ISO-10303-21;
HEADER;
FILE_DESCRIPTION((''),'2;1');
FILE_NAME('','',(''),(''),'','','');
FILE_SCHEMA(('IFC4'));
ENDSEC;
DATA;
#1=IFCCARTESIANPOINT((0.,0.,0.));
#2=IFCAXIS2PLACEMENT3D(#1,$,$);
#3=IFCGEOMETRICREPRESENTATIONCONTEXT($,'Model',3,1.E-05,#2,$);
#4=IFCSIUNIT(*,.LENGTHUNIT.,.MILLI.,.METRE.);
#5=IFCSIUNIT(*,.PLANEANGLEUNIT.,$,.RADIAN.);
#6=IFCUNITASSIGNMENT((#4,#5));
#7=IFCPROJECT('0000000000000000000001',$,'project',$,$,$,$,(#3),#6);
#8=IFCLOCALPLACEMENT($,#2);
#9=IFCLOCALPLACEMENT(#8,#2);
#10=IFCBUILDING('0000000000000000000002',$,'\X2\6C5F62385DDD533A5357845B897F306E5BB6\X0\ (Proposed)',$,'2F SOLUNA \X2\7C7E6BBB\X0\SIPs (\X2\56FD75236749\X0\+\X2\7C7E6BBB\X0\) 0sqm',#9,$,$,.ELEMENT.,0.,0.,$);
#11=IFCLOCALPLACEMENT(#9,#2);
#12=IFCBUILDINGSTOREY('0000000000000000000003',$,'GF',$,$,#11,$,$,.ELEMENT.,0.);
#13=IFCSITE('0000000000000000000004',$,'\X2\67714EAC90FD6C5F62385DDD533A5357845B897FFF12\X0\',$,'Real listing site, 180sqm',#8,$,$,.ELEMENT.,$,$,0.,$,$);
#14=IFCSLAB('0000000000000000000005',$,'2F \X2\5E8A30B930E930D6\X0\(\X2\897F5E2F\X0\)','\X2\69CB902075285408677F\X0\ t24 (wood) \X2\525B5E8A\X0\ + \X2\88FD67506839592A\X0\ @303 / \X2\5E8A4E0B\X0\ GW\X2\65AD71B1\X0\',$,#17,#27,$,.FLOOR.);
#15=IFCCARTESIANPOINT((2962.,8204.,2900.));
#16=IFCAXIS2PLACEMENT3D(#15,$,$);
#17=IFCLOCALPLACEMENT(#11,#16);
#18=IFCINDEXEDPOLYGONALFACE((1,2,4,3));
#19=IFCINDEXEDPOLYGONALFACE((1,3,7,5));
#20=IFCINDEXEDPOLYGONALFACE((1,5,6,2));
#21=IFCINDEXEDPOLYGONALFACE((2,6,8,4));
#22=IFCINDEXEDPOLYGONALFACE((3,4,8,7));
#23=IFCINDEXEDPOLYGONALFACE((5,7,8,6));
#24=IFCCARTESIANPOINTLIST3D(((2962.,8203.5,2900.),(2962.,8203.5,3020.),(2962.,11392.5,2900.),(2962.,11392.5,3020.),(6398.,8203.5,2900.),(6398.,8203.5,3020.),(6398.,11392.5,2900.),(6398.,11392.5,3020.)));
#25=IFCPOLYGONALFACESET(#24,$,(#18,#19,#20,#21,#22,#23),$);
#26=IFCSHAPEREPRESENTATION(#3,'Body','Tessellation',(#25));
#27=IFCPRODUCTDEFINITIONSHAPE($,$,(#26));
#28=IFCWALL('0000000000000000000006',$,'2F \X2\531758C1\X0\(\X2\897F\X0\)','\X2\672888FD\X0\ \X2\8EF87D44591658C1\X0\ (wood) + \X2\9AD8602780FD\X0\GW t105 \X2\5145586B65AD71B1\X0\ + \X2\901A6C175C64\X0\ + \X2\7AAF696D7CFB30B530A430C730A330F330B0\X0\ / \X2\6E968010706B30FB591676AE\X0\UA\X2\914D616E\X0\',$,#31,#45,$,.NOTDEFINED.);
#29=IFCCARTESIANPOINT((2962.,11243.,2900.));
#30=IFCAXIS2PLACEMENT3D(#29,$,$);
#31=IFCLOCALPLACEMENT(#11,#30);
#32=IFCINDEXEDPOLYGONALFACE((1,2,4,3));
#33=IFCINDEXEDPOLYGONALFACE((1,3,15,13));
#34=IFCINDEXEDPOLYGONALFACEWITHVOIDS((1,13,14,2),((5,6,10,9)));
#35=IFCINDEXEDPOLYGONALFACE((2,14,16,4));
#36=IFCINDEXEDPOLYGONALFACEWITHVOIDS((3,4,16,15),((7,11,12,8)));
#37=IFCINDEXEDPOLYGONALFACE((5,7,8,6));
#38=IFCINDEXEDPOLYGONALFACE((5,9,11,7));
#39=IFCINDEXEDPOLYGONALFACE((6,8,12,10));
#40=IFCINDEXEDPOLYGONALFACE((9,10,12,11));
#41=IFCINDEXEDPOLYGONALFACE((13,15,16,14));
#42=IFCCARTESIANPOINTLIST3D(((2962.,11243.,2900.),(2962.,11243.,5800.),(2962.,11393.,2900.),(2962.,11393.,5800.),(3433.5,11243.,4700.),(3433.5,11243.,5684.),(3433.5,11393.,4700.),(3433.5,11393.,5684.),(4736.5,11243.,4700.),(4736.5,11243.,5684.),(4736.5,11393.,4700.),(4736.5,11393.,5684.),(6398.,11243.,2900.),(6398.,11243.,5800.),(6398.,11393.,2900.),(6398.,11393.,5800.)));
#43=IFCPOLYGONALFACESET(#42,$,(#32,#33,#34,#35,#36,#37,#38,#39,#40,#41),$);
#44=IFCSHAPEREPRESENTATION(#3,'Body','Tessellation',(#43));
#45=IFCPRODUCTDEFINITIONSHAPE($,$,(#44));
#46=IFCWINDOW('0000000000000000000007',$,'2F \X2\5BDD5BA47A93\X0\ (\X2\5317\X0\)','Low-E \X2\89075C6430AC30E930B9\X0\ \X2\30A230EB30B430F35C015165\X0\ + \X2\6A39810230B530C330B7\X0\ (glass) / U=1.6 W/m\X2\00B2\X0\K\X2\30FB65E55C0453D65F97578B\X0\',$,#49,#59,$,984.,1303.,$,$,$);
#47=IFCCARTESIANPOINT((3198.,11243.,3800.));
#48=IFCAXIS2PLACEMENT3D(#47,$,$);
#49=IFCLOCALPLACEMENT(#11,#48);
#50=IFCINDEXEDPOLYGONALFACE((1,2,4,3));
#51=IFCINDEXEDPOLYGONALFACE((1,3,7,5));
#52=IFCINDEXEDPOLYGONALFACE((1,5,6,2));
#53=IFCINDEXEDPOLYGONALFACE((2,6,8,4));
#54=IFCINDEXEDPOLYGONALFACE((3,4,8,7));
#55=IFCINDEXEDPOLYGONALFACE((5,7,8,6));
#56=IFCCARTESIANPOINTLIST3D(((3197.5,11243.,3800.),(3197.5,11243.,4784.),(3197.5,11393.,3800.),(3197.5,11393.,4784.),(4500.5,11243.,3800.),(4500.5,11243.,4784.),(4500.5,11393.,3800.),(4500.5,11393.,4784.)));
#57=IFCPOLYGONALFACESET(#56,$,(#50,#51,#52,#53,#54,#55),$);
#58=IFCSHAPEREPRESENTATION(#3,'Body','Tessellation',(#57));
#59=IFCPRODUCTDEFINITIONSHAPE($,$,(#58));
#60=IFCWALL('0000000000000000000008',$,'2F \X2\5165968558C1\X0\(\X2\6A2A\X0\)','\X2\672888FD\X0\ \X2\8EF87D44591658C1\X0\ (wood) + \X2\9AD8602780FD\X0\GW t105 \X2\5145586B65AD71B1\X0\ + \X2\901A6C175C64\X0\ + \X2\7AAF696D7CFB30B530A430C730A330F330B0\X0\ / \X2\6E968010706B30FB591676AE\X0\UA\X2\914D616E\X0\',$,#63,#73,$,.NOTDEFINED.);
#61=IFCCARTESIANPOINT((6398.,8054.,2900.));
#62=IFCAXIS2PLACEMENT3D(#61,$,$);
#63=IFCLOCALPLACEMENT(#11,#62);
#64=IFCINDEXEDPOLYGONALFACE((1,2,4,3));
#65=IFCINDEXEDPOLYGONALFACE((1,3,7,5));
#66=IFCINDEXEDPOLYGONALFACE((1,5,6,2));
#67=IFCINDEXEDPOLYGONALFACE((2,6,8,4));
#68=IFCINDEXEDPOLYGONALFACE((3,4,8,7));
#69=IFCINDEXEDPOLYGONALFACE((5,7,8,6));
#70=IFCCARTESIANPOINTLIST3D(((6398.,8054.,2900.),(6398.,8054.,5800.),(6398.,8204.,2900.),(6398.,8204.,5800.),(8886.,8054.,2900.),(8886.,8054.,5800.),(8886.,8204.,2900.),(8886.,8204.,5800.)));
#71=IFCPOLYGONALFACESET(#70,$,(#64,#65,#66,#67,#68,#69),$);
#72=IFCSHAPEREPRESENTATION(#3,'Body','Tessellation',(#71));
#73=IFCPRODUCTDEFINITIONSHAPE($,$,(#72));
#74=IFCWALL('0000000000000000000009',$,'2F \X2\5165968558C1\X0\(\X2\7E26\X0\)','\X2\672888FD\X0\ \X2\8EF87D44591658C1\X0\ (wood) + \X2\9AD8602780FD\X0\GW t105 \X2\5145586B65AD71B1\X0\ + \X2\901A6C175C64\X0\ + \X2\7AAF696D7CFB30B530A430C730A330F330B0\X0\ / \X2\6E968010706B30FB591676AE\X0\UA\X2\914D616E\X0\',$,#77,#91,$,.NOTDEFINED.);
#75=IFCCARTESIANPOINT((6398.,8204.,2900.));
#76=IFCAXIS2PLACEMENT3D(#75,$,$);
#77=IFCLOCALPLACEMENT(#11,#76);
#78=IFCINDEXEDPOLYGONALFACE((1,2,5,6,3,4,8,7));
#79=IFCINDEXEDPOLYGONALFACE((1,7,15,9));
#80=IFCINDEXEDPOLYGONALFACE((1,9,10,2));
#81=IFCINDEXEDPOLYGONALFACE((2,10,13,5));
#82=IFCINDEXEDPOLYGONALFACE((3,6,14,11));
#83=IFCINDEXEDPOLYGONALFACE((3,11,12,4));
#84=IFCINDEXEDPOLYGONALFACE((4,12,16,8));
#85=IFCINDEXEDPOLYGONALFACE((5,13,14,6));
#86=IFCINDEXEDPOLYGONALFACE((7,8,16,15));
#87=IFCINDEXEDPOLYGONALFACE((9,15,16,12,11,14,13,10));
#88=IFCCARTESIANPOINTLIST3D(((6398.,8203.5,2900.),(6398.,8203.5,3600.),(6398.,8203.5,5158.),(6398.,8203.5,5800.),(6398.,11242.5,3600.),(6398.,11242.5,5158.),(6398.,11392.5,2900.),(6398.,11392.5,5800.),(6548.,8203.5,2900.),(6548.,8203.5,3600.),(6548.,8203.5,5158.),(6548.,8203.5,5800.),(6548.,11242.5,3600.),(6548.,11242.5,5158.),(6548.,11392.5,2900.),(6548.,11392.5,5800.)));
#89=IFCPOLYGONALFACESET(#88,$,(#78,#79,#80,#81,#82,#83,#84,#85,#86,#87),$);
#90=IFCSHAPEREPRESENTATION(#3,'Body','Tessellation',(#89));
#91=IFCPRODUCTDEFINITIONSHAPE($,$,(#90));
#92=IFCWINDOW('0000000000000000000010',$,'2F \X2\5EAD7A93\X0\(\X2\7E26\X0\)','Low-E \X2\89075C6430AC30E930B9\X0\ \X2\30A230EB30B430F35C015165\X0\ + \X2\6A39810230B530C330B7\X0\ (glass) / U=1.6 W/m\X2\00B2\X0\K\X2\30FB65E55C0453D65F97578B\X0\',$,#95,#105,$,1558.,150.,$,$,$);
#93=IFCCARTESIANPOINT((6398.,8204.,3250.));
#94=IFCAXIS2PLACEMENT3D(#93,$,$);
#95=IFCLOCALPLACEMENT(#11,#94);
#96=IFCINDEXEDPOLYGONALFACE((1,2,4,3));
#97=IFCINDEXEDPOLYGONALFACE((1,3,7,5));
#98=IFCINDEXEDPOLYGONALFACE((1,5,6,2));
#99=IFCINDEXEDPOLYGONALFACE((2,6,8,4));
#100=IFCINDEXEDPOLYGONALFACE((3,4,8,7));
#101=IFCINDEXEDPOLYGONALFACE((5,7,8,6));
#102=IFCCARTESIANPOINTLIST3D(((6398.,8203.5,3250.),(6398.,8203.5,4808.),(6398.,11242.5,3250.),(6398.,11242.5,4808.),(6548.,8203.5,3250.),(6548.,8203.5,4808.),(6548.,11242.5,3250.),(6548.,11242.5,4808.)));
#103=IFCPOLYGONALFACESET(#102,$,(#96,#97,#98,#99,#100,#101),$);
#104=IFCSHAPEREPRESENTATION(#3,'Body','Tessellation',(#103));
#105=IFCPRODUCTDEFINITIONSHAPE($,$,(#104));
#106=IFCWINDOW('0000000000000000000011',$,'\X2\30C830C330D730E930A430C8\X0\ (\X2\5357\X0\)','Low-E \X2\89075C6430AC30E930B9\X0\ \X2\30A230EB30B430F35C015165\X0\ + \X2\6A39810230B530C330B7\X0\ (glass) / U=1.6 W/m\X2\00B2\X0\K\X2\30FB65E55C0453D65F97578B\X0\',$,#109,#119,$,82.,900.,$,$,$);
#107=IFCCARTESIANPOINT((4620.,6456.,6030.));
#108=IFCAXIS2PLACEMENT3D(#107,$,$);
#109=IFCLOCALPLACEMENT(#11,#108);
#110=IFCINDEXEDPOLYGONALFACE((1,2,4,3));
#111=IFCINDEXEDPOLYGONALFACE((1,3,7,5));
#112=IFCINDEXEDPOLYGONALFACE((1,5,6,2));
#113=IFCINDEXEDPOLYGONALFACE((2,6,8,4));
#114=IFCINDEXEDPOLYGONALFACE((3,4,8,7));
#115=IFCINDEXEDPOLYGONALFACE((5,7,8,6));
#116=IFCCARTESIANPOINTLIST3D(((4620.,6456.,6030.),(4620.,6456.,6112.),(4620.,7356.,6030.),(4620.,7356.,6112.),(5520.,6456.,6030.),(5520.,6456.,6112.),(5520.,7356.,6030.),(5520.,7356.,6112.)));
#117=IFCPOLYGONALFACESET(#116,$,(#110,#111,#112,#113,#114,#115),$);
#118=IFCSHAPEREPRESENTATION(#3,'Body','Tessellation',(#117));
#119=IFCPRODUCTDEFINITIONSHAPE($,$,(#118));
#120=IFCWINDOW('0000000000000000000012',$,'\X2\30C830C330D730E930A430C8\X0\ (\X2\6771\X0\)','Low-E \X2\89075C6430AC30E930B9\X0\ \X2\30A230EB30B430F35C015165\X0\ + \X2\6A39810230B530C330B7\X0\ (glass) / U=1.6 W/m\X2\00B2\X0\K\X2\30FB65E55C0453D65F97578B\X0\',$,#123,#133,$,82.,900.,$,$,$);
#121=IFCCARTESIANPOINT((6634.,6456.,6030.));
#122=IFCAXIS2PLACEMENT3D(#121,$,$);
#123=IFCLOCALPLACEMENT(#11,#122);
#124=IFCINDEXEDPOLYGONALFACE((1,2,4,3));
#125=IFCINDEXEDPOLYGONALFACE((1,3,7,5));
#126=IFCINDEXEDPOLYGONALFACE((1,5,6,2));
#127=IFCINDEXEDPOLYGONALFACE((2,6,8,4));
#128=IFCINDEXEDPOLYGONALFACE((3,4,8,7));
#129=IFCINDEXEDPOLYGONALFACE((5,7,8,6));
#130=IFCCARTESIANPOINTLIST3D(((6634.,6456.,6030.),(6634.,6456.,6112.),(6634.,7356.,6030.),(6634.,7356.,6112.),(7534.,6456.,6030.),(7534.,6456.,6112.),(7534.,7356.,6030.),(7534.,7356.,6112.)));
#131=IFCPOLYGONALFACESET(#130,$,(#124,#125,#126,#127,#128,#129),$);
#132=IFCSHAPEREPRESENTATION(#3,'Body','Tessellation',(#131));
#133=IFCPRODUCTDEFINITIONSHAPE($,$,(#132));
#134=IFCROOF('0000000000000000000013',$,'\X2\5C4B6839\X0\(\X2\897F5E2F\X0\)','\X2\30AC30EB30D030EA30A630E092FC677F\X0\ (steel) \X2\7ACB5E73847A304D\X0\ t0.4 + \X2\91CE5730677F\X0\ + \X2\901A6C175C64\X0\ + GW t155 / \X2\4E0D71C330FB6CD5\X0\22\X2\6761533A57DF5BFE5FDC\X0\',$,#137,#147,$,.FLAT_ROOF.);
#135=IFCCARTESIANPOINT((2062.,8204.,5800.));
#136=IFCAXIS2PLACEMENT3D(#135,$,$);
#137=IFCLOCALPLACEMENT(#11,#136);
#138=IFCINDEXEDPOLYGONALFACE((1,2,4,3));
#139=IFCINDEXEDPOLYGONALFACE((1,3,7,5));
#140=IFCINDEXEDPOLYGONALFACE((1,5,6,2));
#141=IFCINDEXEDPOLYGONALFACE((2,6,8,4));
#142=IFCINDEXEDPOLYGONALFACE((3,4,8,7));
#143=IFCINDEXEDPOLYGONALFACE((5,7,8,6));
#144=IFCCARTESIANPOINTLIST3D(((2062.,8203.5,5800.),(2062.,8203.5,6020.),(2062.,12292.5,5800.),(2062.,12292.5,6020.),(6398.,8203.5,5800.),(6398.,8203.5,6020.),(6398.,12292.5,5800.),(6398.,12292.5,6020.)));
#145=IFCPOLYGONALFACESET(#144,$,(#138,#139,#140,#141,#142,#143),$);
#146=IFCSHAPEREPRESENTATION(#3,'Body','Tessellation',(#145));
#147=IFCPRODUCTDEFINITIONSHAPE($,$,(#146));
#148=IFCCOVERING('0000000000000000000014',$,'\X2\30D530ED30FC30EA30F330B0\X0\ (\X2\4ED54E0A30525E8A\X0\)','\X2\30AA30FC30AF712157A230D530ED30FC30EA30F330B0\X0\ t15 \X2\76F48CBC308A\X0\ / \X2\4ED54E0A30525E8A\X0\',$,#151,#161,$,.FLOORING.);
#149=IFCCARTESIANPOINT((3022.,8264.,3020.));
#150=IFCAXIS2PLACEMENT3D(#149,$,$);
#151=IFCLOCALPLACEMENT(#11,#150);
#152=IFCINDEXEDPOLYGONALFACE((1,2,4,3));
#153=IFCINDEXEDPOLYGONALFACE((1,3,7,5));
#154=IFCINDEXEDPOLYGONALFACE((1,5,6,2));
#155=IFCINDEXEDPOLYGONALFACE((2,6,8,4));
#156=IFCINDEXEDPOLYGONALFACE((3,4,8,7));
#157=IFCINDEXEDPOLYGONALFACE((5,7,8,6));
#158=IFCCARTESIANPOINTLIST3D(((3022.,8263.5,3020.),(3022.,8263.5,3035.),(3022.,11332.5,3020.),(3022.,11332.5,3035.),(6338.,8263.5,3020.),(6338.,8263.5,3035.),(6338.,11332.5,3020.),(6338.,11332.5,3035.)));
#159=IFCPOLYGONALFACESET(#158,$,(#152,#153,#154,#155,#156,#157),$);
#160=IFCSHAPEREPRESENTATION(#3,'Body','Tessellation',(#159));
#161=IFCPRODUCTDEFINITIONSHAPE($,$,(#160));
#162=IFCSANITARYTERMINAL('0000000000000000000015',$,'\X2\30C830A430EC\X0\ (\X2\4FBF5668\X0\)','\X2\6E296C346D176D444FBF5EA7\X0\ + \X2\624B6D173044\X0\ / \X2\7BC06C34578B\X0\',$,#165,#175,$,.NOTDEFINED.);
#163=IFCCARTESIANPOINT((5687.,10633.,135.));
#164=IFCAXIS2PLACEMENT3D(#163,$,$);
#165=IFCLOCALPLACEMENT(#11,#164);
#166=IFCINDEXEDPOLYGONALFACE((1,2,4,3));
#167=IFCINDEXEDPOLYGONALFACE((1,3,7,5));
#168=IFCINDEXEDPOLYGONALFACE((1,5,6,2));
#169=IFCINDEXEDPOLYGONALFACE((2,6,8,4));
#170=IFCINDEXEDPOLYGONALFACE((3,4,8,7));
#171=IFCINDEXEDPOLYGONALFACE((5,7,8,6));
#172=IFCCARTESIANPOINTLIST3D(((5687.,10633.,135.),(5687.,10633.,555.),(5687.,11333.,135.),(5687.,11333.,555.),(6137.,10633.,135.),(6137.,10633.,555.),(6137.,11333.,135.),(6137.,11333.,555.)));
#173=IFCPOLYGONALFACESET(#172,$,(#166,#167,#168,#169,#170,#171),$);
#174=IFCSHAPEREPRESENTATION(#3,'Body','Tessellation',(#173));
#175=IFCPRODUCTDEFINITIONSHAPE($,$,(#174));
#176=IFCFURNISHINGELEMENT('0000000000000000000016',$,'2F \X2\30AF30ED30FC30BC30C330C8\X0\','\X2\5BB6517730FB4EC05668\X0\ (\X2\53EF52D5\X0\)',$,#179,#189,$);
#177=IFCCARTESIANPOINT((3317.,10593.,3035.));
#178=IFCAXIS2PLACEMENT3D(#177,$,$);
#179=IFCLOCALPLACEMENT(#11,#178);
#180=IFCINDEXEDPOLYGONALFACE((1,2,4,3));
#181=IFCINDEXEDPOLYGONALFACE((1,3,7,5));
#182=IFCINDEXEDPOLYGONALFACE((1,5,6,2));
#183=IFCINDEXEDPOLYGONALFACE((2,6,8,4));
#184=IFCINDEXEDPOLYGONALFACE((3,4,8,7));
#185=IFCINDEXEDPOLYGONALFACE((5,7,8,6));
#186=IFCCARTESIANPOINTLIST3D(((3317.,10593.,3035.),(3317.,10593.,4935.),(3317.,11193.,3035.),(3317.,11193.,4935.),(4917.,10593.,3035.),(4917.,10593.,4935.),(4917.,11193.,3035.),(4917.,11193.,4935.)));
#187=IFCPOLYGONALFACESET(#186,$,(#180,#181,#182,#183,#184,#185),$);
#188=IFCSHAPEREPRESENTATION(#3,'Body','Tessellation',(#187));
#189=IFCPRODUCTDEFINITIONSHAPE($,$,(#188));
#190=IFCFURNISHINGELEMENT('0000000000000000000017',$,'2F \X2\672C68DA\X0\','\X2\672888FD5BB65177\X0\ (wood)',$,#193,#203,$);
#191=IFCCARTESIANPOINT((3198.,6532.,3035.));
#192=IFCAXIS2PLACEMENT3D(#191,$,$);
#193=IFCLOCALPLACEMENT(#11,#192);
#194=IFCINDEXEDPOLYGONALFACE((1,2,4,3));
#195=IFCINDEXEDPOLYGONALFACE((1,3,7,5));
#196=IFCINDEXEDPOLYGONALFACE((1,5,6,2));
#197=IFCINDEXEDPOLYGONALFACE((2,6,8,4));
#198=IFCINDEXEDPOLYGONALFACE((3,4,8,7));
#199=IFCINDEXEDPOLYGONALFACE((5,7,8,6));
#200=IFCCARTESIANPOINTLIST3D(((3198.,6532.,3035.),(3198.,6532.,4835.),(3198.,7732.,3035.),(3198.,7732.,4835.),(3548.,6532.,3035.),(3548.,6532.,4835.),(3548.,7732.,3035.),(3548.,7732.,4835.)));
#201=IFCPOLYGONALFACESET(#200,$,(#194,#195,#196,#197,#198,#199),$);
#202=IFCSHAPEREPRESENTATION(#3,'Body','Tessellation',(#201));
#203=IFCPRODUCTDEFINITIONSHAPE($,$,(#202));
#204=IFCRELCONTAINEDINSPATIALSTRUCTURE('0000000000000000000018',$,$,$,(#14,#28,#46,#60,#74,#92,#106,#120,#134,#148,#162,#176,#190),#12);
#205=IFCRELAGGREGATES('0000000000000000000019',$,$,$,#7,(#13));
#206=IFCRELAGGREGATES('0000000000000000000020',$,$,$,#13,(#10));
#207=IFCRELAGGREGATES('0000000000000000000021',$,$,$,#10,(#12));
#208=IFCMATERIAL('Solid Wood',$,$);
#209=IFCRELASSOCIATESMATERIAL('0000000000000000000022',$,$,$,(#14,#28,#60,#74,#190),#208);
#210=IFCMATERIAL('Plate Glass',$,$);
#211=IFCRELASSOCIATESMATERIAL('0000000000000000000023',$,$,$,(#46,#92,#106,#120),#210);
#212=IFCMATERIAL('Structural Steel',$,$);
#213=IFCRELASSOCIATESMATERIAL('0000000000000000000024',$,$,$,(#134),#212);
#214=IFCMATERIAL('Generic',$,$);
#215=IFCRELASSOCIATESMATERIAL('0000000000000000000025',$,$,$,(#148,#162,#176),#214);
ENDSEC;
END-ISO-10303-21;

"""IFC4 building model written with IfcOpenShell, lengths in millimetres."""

from ifc_helpers import new_model, si_unit, frame, frame_2d, origin, place, context, project, spatial, rectangle, extrude, material, element, fill, save


model = new_model("IFC4")

# Units and contexts
model_context = context("Model", 3, precision=1e-05, world=origin())
ifc_project = project(units=[si_unit("LENGTHUNIT", "METRE", prefix="MILLI"), si_unit("PLANEANGLEUNIT", "RADIAN")], contexts=[model_context])

# Site, building, storey
site_placement = place(None, origin())
site = spatial("IfcSite", under=ifc_project, at=site_placement, Name="東京都江戸川区南葛西２", ObjectType="Real listing site, 180sqm", CompositionType="ELEMENT", RefElevation=0.0)
building_placement = place(site_placement, origin())
building = spatial("IfcBuilding", under=site, at=building_placement, Name="江戸川区南葛西の家 (Proposed)", ObjectType="2F SOLUNA 籾殻SIPs (国産杉+籾殻) 0sqm", CompositionType="ELEMENT", ElevationOfRefHeight=0.0, ElevationOfTerrain=0.0)
storey_placement = place(building_placement, origin())
storey = spatial("IfcBuildingStorey", under=building, at=storey_placement, Name="GF", CompositionType="ELEMENT", Elevation=0.0)

# Slab
ifc_material_1 = material(Name="Solid Wood")
slab_placement = place(storey_placement, frame((2962.0, 8204.0, 2900.0)))
element("IfcSlab", 1, at=slab_placement, inside=storey, material=ifc_material_1, Name="2F 床スラブ(西帯)", Description="構造用合板 t24 (wood) 剛床 + 製材根太 @303 / 床下 GW断熱", PredefinedType="FLOOR", context=model_context, shape_type="SweptSolid", body=[
    extrude(rectangle(XDim=3436.0, YDim=3189.0, at=frame_2d((1718.0, 1594.0))), frame((2962.0, 8204.0, 2900.0)), (0.0, 0.0, 1.0), 120.0),
])

# Wall, opening, window
wall_1_placement = place(storey_placement, frame((2962.0, 11243.0, 2900.0)))
wall_1 = element("IfcWall", 2, at=wall_1_placement, inside=storey, material=ifc_material_1, Name="2F 北壁(西)", Description="木製 軸組外壁 (wood) + 高性能GW t105 充填断熱 + 通気層 + 窯業系サイディング / 準耐火・外皮UA配慮", PredefinedType="NOTDEFINED", context=model_context, shape_type="SweptSolid", body=[
    extrude(rectangle(XDim=3436.0, YDim=150.0, at=frame_2d((1718.0, 75.0))), frame((2962.0, 11243.0, 2900.0)), (0.0, 0.0, 1.0), 2900.0),
])
opening_1_placement = place(storey_placement, frame((3198.0, 11243.0, 3800.0)))
opening_1 = element("IfcOpeningElement", 3, at=opening_1_placement, cuts=wall_1, PredefinedType="NOTDEFINED", context=model_context, shape_type="SweptSolid", body=[
    extrude(rectangle(XDim=1303.0, YDim=150.0, at=frame_2d((651.0, 75.0))), frame((3198.0, 11243.0, 3800.0)), (0.0, 0.0, 1.0), 984.0),
])
ifc_material_2 = material(Name="Plate Glass")
window_1_placement = place(storey_placement, frame((3198.0, 11243.0, 3800.0)))
window_1 = element("IfcWindow", 4, at=window_1_placement, inside=storey, material=ifc_material_2, Name="2F 寝室窓 (北)", Description="Low-E 複層ガラス アルゴン封入 + 樹脂サッシ (glass) / U=1.6 W/m²K・日射取得型", OverallHeight=984.0, OverallWidth=1303.0, context=model_context, shape_type="SweptSolid", body=[
    extrude(rectangle(XDim=1303.0, YDim=150.0, at=frame_2d((651.0, 75.0))), frame((3198.0, 11243.0, 3800.0)), (0.0, 0.0, 1.0), 984.0),
])
fill(opening_1, window_1)

# Wall
wall_2_placement = place(storey_placement, frame((6398.0, 8054.0, 2900.0)))
element("IfcWall", 5, at=wall_2_placement, inside=storey, material=ifc_material_1, Name="2F 入隅壁(横)", Description="木製 軸組外壁 (wood) + 高性能GW t105 充填断熱 + 通気層 + 窯業系サイディング / 準耐火・外皮UA配慮", PredefinedType="NOTDEFINED", context=model_context, shape_type="SweptSolid", body=[
    extrude(rectangle(XDim=2488.0, YDim=150.0, at=frame_2d((1244.0, 75.0))), frame((6398.0, 8054.0, 2900.0)), (0.0, 0.0, 1.0), 2900.0),
])

# Wall, opening, window
wall_3_placement = place(storey_placement, frame((6398.0, 8204.0, 2900.0)))
wall_3 = element("IfcWall", 6, at=wall_3_placement, inside=storey, material=ifc_material_1, Name="2F 入隅壁(縦)", Description="木製 軸組外壁 (wood) + 高性能GW t105 充填断熱 + 通気層 + 窯業系サイディング / 準耐火・外皮UA配慮", PredefinedType="NOTDEFINED", context=model_context, shape_type="SweptSolid", body=[
    extrude(rectangle(XDim=150.0, YDim=3189.0, at=frame_2d((75.0, 1594.0))), frame((6398.0, 8204.0, 2900.0)), (0.0, 0.0, 1.0), 2900.0),
])
opening_2_placement = place(storey_placement, frame((6398.0, 8204.0, 3250.0)))
opening_2 = element("IfcOpeningElement", 7, at=opening_2_placement, cuts=wall_3, PredefinedType="NOTDEFINED", context=model_context, shape_type="SweptSolid", body=[
    extrude(rectangle(XDim=150.0, YDim=3039.0, at=frame_2d((75.0, 1519.0))), frame((6398.0, 8204.0, 3250.0)), (0.0, 0.0, 1.0), 1558.0),
])
window_2_placement = place(storey_placement, frame((6398.0, 8204.0, 3250.0)))
window_2 = element("IfcWindow", 8, at=window_2_placement, inside=storey, material=ifc_material_2, Name="2F 庭窓(縦)", Description="Low-E 複層ガラス アルゴン封入 + 樹脂サッシ (glass) / U=1.6 W/m²K・日射取得型", OverallHeight=1558.0, OverallWidth=150.0, context=model_context, shape_type="SweptSolid", body=[
    extrude(rectangle(XDim=150.0, YDim=3039.0, at=frame_2d((75.0, 1519.0))), frame((6398.0, 8204.0, 3250.0)), (0.0, 0.0, 1.0), 1558.0),
])
fill(opening_2, window_2)

# Windows
window_3_placement = place(storey_placement, frame((4620.0, 6456.0, 6030.0)))
element("IfcWindow", 9, at=window_3_placement, inside=storey, material=ifc_material_2, Name="トップライト (南)", Description="Low-E 複層ガラス アルゴン封入 + 樹脂サッシ (glass) / U=1.6 W/m²K・日射取得型", OverallHeight=82.0, OverallWidth=900.0, context=model_context, shape_type="SweptSolid", body=[
    extrude(rectangle(XDim=900.0, YDim=900.0, at=frame_2d((450.0, 450.0))), frame((4620.0, 6456.0, 6030.0)), (0.0, 0.0, 1.0), 82.0),
])
window_4_placement = place(storey_placement, frame((6634.0, 6456.0, 6030.0)))
element("IfcWindow", 10, at=window_4_placement, inside=storey, material=ifc_material_2, Name="トップライト (東)", Description="Low-E 複層ガラス アルゴン封入 + 樹脂サッシ (glass) / U=1.6 W/m²K・日射取得型", OverallHeight=82.0, OverallWidth=900.0, context=model_context, shape_type="SweptSolid", body=[
    extrude(rectangle(XDim=900.0, YDim=900.0, at=frame_2d((450.0, 450.0))), frame((6634.0, 6456.0, 6030.0)), (0.0, 0.0, 1.0), 82.0),
])

# Roof
ifc_material_3 = material(Name="Structural Steel")
for number, where, name in (
    (11, (2062.0, 8204.0, 5800.0), "屋根(西帯)"),
):
    element("IfcRoof", number, at=place(storey_placement, frame(where)), inside=storey, material=ifc_material_3, Name=name, Description="ガルバリウム鋼板 (steel) 立平葺き t0.4 + 野地板 + 通気層 + GW t155 / 不燃・法22条区域対応", PredefinedType="FLAT_ROOF", context=model_context, shape_type="SweptSolid", body=[
        extrude(rectangle(XDim=4336.0, YDim=4089.0, at=frame_2d((2168.0, 2044.0))), frame((2062.0, 8204.0, 5800.0)), (0.0, 0.0, 1.0), 220.0),
    ])

# Covering
ifc_material_4 = material(Name="Generic")
covering_placement = place(storey_placement, frame((3022.0, 8264.0, 3020.0)))
element("IfcCovering", 12, at=covering_placement, inside=storey, material=ifc_material_4, Name="フローリング (仕上げ床)", Description="オーク無垢フローリング t15 直貼り / 仕上げ床", PredefinedType="FLOORING", context=model_context, shape_type="SweptSolid", body=[
    extrude(rectangle(XDim=3316.0, YDim=3069.0, at=frame_2d((1658.0, 1534.0))), frame((3022.0, 8264.0, 3020.0)), (0.0, 0.0, 1.0), 15.0),
])

# Sanitary terminal
sanitary_terminal_placement = place(storey_placement, frame((5687.0, 10633.0, 135.0)))
element("IfcSanitaryTerminal", 13, at=sanitary_terminal_placement, inside=storey, material=ifc_material_4, Name="トイレ (便器)", Description="温水洗浄便座 + 手洗い / 節水型", PredefinedType="NOTDEFINED", context=model_context, shape_type="SweptSolid", body=[
    extrude(rectangle(XDim=450.0, YDim=700.0, at=frame_2d((225.0, 350.0))), frame((5687.0, 10633.0, 135.0)), (0.0, 0.0, 1.0), 420.0),
])

# Furnishing elements
furnishing_1_placement = place(storey_placement, frame((3317.0, 10593.0, 3035.0)))
element("IfcFurnishingElement", 14, at=furnishing_1_placement, inside=storey, material=ifc_material_4, Name="2F クローゼット", Description="家具・什器 (可動)", context=model_context, shape_type="SweptSolid", body=[
    extrude(rectangle(XDim=1600.0, YDim=600.0, at=frame_2d((800.0, 300.0))), frame((3317.0, 10593.0, 3035.0)), (0.0, 0.0, 1.0), 1900.0),
])
furnishing_2_placement = place(storey_placement, frame((3198.0, 6532.0, 3035.0)))
element("IfcFurnishingElement", 15, at=furnishing_2_placement, inside=storey, material=ifc_material_1, Name="2F 本棚", Description="木製家具 (wood)", context=model_context, shape_type="SweptSolid", body=[
    extrude(rectangle(XDim=350.0, YDim=1200.0, at=frame_2d((175.0, 600.0))), frame((3198.0, 6532.0, 3035.0)), (0.0, 0.0, 1.0), 1800.0),
])

save(model, "model.ifc")
